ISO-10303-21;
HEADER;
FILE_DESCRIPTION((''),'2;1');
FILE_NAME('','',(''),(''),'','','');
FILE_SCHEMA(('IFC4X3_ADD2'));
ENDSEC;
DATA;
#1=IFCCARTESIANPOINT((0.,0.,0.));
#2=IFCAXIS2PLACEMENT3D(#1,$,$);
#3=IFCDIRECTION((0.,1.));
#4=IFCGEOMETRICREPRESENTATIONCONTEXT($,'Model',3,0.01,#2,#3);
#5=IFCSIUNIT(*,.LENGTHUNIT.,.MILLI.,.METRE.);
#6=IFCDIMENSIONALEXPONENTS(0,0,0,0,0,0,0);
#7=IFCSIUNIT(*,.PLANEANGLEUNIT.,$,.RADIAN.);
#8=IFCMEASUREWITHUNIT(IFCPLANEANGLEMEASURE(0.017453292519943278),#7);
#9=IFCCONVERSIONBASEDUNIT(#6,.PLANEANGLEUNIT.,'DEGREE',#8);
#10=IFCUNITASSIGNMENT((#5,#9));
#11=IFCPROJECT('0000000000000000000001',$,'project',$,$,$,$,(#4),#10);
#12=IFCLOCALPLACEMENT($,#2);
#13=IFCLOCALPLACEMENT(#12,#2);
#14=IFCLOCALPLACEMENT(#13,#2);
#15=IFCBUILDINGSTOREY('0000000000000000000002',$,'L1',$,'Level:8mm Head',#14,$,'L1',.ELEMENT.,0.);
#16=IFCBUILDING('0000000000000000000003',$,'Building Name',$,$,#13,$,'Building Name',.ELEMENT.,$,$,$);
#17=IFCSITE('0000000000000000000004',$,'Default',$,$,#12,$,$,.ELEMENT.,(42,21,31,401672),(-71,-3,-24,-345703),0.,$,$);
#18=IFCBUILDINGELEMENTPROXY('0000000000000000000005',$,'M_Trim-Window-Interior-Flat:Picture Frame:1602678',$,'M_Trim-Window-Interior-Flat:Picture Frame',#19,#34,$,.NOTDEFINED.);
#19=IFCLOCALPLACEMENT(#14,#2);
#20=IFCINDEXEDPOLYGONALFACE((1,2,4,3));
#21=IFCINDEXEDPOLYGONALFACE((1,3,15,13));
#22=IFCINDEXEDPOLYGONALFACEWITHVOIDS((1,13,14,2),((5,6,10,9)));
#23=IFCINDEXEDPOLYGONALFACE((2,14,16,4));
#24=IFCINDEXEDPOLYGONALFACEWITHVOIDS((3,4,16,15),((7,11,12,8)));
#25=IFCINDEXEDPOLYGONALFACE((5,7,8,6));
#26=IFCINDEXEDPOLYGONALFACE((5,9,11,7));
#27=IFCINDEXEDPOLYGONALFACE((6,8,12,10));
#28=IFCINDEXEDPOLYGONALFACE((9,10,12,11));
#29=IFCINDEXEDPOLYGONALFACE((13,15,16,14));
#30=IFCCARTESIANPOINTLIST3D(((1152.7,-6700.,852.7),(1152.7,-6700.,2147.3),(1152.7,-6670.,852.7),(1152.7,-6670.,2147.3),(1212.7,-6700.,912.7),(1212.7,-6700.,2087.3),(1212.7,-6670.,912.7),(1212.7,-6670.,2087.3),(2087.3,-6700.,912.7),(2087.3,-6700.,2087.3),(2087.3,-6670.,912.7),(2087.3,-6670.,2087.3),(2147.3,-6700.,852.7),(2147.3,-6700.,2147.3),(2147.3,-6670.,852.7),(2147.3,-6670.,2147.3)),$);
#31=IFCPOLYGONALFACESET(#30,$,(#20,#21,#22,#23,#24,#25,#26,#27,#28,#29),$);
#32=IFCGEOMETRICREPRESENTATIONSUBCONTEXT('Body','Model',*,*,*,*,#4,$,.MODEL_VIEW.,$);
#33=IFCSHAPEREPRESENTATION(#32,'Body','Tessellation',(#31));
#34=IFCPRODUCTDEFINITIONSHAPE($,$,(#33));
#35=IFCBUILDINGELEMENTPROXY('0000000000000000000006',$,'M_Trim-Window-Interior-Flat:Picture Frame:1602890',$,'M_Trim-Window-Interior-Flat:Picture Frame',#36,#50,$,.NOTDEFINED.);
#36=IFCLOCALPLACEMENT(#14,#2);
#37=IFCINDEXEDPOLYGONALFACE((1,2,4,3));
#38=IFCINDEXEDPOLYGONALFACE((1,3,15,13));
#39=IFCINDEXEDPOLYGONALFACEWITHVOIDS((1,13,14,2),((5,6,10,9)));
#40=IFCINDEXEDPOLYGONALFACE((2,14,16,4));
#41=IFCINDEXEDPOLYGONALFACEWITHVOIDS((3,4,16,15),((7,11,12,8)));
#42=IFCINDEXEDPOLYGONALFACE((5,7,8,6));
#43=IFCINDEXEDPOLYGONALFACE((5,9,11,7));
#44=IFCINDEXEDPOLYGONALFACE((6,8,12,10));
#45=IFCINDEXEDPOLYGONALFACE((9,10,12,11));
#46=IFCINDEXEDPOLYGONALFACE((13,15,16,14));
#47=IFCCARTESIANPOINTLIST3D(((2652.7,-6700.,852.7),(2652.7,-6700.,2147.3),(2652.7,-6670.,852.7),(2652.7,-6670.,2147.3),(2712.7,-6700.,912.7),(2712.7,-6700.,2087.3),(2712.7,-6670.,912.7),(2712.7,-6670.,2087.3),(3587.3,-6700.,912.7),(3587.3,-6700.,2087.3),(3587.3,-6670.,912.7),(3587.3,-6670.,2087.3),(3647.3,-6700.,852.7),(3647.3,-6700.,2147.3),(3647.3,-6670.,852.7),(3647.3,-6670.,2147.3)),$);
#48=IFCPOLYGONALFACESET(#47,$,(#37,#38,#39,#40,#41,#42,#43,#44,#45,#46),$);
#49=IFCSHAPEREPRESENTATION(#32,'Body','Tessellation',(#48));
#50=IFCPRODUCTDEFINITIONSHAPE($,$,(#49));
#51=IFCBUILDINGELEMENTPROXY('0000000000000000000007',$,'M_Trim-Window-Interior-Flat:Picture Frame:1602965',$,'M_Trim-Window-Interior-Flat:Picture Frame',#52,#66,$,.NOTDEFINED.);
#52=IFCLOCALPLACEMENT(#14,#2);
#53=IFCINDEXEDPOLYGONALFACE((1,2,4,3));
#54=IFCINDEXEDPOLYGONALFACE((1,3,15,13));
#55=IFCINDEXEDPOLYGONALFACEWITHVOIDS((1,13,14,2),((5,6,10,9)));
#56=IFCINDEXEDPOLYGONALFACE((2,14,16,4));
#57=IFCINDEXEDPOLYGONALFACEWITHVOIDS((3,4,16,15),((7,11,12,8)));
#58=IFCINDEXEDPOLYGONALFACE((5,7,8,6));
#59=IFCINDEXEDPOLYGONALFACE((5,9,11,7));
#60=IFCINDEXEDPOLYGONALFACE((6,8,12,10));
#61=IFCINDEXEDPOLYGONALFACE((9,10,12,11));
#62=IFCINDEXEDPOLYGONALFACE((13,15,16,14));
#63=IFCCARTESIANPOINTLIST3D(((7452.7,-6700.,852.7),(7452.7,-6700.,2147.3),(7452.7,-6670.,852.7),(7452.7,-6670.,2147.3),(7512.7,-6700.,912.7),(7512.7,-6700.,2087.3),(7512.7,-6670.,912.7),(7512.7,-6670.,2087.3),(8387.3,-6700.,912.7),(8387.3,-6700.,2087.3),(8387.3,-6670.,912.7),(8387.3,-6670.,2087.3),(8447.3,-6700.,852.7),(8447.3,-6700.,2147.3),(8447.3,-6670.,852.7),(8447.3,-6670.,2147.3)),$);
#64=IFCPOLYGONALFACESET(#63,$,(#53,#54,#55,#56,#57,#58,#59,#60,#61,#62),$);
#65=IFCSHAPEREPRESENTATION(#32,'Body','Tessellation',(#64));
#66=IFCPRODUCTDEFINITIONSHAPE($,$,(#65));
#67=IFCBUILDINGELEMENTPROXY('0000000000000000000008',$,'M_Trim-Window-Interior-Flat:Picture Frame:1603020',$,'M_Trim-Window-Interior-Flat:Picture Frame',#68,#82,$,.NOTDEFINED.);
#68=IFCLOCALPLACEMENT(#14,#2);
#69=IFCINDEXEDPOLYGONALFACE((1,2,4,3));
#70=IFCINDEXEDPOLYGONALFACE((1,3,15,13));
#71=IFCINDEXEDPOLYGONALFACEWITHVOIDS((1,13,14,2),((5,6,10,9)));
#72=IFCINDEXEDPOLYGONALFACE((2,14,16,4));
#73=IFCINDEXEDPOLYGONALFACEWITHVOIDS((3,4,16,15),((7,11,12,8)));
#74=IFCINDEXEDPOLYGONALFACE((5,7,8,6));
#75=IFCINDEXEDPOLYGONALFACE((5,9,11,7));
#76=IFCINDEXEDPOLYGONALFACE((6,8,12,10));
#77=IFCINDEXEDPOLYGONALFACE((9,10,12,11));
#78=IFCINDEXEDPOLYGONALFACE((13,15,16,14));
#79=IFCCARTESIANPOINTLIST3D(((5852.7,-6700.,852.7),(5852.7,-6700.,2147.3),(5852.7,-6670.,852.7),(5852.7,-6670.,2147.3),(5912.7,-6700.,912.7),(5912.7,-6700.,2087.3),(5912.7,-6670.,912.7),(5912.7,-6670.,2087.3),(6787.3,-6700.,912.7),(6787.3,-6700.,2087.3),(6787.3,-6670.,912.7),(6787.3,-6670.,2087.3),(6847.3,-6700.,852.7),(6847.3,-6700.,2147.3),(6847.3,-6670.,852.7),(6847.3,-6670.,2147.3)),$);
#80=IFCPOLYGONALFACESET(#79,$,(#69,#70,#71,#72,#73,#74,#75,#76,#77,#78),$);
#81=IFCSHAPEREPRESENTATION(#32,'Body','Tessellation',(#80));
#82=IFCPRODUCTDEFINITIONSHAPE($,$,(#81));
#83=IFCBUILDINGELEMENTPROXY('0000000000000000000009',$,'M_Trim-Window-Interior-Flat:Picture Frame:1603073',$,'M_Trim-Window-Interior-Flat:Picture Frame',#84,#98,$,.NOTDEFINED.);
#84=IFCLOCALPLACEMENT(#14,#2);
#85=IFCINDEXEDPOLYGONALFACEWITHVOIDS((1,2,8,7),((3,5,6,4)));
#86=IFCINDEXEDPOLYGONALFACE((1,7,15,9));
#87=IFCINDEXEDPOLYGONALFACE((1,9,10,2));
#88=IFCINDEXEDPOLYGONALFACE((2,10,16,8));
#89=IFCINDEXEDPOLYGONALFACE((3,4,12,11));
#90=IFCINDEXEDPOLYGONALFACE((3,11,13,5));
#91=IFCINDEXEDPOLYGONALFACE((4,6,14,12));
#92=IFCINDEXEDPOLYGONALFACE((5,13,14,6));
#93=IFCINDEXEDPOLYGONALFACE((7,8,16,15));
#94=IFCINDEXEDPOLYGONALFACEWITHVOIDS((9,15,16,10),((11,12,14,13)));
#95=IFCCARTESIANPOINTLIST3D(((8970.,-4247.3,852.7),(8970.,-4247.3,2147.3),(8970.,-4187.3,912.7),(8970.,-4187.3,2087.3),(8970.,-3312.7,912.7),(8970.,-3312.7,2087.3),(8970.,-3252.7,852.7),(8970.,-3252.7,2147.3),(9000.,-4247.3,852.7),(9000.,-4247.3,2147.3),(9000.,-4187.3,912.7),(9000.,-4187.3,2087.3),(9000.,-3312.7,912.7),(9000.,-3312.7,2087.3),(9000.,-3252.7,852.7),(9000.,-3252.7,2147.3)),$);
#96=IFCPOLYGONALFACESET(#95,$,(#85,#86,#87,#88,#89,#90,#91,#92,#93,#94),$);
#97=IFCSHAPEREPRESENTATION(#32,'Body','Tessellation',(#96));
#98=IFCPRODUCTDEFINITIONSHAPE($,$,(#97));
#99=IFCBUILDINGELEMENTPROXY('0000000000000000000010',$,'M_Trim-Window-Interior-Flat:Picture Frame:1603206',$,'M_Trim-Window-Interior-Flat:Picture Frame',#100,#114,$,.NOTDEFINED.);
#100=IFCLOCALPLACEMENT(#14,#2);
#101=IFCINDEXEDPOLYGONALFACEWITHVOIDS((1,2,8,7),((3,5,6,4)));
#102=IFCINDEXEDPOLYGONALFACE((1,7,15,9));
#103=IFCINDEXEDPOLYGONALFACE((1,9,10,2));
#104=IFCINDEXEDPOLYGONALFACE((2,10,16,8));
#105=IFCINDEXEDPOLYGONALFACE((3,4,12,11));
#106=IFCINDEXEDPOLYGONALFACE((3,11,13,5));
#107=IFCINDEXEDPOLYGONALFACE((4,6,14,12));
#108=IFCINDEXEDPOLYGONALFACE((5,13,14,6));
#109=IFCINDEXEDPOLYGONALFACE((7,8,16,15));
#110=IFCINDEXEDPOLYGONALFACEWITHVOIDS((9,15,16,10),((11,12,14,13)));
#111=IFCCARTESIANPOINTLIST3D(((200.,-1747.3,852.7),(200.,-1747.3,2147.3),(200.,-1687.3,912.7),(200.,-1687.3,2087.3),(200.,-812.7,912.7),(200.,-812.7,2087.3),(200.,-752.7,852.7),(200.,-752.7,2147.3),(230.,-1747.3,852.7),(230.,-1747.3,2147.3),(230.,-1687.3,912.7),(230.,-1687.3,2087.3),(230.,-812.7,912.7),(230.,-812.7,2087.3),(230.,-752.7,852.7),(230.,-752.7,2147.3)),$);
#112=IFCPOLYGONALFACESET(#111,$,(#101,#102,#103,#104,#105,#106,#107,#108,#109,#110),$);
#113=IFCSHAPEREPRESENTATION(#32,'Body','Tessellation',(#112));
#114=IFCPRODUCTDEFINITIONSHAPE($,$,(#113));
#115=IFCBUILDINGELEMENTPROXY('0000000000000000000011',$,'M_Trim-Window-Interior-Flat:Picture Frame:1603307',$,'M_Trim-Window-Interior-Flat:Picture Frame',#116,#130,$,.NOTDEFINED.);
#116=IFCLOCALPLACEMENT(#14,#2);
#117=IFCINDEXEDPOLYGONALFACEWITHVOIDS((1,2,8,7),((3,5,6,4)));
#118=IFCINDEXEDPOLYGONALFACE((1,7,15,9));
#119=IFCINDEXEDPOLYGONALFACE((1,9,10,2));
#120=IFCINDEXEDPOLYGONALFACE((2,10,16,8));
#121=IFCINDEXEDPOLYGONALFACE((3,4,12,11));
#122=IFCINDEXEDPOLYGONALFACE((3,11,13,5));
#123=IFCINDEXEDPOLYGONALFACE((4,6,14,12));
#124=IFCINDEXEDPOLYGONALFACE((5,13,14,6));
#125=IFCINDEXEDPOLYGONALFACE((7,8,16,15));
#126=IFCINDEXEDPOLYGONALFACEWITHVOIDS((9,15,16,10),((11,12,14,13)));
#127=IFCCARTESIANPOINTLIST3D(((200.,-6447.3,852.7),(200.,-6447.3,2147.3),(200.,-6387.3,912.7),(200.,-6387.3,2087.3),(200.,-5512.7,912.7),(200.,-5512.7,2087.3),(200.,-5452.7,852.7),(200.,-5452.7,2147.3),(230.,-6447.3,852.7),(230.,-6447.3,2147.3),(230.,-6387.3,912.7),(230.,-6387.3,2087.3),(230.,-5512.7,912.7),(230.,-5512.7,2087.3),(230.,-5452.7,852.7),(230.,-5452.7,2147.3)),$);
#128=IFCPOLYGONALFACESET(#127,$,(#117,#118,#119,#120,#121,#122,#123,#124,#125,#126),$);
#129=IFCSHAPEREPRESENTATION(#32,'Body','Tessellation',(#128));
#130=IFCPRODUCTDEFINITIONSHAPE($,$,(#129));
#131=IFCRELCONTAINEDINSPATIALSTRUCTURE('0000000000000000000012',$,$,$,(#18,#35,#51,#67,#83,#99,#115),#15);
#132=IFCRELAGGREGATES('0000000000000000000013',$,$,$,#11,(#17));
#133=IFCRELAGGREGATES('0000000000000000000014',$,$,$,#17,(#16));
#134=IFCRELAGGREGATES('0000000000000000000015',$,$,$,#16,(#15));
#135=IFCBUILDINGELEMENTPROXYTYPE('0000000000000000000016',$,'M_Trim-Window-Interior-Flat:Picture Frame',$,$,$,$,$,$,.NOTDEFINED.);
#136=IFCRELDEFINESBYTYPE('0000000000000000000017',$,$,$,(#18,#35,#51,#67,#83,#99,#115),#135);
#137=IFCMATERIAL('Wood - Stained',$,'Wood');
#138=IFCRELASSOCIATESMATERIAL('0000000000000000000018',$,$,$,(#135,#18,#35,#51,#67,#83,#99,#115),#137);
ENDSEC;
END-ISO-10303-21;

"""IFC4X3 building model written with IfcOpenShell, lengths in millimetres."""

from ifc_helpers import new_model, entity, si_unit, converted_unit, direction, frame, origin, place, context, subcontext, project, spatial, polyline, outline, extrude, source, transform, mapped, material, type_object, type_shapes, element, save


model = new_model("IFC4X3")

# Units and contexts
model_context = context("Model", 3, precision=0.01, world=origin(), true_north=direction((0.0, 1.0)))
body_context = subcontext(model_context, "Body", "Model", "MODEL_VIEW")
ifc_project = project(units=[si_unit("LENGTHUNIT", "METRE", prefix="MILLI"), converted_unit("PLANEANGLEUNIT", "DEGREE", entity("IfcPlaneAngleMeasure", 0.017453292519943278), si_unit("PLANEANGLEUNIT", "RADIAN"), dimensions=[0, 0, 0, 0, 0, 0, 0])], contexts=[model_context])

# Site, building, storey
site_placement = place(None, origin())
site = spatial("IfcSite", under=ifc_project, at=site_placement, Name="Default", CompositionType="ELEMENT", RefLatitude=(42, 21, 31, 401672), RefLongitude=(-71, -3, -24, -345703), RefElevation=0.0)
building_placement = place(site_placement, origin())
building = spatial("IfcBuilding", under=site, at=building_placement, Name="Building Name", LongName="Building Name", CompositionType="ELEMENT")
storey_placement = place(building_placement, origin())
storey = spatial("IfcBuildingStorey", under=building, at=storey_placement, Name="L1", ObjectType="Level:8mm Head", LongName="L1", CompositionType="ELEMENT", Elevation=0.0)

# Building element proxies
ifc_material_1 = material(Name="Wood - Stained", Category="Wood")
building_element_proxy_type_1 = type_object("IfcBuildingElementProxyType", Name="M_Trim-Window-Interior-Flat:Picture Frame", PredefinedType="NOTDEFINED", material=ifc_material_1)
shared_shape_1 = source(origin(), body_context, "Body", "SweptSolid", [
    extrude(outline(polyline([(-497.3, -647.3), (497.3, -647.3), (497.3, 647.3), (-497.3, 647.3), (-497.3, -647.3)]), holes=[polyline([(-437.3, -587.3), (-437.3, 587.3), (437.3, 587.3), (437.3, -587.3), (-437.3, -587.3)])]), frame((0.0, -600.0, 0.0), z_axis=(0.0, 0.0, 1.0), x_axis=(-1.0, 0.0, 0.0)), (0.0, 0.0, 1.0), 30.0),
])
type_shapes(building_element_proxy_type_1, [shared_shape_1])
for number, where, z_axis, x_axis, name in (
    (1, (1650.0, -6700.0, 2100.0), (0.0, 1.0, 0.0), (-1.0, 0.0, 0.0), "M_Trim-Window-Interior-Flat:Picture Frame:1602678"),
    (2, (3150.0, -6700.0, 2100.0), (0.0, 1.0, 0.0), (-1.0, 0.0, 0.0), "M_Trim-Window-Interior-Flat:Picture Frame:1602890"),
    (3, (7950.0, -6700.0, 2100.0), (0.0, 1.0, 0.0), (-1.0, 0.0, 0.0), "M_Trim-Window-Interior-Flat:Picture Frame:1602965"),
    (4, (6350.0, -6700.0, 2100.0), (0.0, 1.0, 0.0), (-1.0, 0.0, 0.0), "M_Trim-Window-Interior-Flat:Picture Frame:1603020"),
    (5, (9000.0, -3750.0, 2100.0), (-1.0, 0.0, 0.0), (0.0, -1.0, 0.0), "M_Trim-Window-Interior-Flat:Picture Frame:1603073"),
    (6, (200.0, -1250.0, 2100.0), (1.0, 0.0, 0.0), (0.0, 1.0, 0.0), "M_Trim-Window-Interior-Flat:Picture Frame:1603206"),
    (7, (200.0, -5950.0, 2100.0), (1.0, 0.0, 0.0), (0.0, 1.0, 0.0), "M_Trim-Window-Interior-Flat:Picture Frame:1603307"),
):
    element("IfcBuildingElementProxy", number, at=place(storey_placement, frame(where, z_axis=z_axis, x_axis=x_axis)), inside=storey, type_object=building_element_proxy_type_1, material=ifc_material_1, Name=name, ObjectType="M_Trim-Window-Interior-Flat:Picture Frame", PredefinedType="NOTDEFINED", context=body_context, shape_type="MappedRepresentation", body=[
        mapped(shared_shape_1, transform((0.0, 0.0, 0.0), scale=1.0)),
    ])

save(model, "model.ifc")
